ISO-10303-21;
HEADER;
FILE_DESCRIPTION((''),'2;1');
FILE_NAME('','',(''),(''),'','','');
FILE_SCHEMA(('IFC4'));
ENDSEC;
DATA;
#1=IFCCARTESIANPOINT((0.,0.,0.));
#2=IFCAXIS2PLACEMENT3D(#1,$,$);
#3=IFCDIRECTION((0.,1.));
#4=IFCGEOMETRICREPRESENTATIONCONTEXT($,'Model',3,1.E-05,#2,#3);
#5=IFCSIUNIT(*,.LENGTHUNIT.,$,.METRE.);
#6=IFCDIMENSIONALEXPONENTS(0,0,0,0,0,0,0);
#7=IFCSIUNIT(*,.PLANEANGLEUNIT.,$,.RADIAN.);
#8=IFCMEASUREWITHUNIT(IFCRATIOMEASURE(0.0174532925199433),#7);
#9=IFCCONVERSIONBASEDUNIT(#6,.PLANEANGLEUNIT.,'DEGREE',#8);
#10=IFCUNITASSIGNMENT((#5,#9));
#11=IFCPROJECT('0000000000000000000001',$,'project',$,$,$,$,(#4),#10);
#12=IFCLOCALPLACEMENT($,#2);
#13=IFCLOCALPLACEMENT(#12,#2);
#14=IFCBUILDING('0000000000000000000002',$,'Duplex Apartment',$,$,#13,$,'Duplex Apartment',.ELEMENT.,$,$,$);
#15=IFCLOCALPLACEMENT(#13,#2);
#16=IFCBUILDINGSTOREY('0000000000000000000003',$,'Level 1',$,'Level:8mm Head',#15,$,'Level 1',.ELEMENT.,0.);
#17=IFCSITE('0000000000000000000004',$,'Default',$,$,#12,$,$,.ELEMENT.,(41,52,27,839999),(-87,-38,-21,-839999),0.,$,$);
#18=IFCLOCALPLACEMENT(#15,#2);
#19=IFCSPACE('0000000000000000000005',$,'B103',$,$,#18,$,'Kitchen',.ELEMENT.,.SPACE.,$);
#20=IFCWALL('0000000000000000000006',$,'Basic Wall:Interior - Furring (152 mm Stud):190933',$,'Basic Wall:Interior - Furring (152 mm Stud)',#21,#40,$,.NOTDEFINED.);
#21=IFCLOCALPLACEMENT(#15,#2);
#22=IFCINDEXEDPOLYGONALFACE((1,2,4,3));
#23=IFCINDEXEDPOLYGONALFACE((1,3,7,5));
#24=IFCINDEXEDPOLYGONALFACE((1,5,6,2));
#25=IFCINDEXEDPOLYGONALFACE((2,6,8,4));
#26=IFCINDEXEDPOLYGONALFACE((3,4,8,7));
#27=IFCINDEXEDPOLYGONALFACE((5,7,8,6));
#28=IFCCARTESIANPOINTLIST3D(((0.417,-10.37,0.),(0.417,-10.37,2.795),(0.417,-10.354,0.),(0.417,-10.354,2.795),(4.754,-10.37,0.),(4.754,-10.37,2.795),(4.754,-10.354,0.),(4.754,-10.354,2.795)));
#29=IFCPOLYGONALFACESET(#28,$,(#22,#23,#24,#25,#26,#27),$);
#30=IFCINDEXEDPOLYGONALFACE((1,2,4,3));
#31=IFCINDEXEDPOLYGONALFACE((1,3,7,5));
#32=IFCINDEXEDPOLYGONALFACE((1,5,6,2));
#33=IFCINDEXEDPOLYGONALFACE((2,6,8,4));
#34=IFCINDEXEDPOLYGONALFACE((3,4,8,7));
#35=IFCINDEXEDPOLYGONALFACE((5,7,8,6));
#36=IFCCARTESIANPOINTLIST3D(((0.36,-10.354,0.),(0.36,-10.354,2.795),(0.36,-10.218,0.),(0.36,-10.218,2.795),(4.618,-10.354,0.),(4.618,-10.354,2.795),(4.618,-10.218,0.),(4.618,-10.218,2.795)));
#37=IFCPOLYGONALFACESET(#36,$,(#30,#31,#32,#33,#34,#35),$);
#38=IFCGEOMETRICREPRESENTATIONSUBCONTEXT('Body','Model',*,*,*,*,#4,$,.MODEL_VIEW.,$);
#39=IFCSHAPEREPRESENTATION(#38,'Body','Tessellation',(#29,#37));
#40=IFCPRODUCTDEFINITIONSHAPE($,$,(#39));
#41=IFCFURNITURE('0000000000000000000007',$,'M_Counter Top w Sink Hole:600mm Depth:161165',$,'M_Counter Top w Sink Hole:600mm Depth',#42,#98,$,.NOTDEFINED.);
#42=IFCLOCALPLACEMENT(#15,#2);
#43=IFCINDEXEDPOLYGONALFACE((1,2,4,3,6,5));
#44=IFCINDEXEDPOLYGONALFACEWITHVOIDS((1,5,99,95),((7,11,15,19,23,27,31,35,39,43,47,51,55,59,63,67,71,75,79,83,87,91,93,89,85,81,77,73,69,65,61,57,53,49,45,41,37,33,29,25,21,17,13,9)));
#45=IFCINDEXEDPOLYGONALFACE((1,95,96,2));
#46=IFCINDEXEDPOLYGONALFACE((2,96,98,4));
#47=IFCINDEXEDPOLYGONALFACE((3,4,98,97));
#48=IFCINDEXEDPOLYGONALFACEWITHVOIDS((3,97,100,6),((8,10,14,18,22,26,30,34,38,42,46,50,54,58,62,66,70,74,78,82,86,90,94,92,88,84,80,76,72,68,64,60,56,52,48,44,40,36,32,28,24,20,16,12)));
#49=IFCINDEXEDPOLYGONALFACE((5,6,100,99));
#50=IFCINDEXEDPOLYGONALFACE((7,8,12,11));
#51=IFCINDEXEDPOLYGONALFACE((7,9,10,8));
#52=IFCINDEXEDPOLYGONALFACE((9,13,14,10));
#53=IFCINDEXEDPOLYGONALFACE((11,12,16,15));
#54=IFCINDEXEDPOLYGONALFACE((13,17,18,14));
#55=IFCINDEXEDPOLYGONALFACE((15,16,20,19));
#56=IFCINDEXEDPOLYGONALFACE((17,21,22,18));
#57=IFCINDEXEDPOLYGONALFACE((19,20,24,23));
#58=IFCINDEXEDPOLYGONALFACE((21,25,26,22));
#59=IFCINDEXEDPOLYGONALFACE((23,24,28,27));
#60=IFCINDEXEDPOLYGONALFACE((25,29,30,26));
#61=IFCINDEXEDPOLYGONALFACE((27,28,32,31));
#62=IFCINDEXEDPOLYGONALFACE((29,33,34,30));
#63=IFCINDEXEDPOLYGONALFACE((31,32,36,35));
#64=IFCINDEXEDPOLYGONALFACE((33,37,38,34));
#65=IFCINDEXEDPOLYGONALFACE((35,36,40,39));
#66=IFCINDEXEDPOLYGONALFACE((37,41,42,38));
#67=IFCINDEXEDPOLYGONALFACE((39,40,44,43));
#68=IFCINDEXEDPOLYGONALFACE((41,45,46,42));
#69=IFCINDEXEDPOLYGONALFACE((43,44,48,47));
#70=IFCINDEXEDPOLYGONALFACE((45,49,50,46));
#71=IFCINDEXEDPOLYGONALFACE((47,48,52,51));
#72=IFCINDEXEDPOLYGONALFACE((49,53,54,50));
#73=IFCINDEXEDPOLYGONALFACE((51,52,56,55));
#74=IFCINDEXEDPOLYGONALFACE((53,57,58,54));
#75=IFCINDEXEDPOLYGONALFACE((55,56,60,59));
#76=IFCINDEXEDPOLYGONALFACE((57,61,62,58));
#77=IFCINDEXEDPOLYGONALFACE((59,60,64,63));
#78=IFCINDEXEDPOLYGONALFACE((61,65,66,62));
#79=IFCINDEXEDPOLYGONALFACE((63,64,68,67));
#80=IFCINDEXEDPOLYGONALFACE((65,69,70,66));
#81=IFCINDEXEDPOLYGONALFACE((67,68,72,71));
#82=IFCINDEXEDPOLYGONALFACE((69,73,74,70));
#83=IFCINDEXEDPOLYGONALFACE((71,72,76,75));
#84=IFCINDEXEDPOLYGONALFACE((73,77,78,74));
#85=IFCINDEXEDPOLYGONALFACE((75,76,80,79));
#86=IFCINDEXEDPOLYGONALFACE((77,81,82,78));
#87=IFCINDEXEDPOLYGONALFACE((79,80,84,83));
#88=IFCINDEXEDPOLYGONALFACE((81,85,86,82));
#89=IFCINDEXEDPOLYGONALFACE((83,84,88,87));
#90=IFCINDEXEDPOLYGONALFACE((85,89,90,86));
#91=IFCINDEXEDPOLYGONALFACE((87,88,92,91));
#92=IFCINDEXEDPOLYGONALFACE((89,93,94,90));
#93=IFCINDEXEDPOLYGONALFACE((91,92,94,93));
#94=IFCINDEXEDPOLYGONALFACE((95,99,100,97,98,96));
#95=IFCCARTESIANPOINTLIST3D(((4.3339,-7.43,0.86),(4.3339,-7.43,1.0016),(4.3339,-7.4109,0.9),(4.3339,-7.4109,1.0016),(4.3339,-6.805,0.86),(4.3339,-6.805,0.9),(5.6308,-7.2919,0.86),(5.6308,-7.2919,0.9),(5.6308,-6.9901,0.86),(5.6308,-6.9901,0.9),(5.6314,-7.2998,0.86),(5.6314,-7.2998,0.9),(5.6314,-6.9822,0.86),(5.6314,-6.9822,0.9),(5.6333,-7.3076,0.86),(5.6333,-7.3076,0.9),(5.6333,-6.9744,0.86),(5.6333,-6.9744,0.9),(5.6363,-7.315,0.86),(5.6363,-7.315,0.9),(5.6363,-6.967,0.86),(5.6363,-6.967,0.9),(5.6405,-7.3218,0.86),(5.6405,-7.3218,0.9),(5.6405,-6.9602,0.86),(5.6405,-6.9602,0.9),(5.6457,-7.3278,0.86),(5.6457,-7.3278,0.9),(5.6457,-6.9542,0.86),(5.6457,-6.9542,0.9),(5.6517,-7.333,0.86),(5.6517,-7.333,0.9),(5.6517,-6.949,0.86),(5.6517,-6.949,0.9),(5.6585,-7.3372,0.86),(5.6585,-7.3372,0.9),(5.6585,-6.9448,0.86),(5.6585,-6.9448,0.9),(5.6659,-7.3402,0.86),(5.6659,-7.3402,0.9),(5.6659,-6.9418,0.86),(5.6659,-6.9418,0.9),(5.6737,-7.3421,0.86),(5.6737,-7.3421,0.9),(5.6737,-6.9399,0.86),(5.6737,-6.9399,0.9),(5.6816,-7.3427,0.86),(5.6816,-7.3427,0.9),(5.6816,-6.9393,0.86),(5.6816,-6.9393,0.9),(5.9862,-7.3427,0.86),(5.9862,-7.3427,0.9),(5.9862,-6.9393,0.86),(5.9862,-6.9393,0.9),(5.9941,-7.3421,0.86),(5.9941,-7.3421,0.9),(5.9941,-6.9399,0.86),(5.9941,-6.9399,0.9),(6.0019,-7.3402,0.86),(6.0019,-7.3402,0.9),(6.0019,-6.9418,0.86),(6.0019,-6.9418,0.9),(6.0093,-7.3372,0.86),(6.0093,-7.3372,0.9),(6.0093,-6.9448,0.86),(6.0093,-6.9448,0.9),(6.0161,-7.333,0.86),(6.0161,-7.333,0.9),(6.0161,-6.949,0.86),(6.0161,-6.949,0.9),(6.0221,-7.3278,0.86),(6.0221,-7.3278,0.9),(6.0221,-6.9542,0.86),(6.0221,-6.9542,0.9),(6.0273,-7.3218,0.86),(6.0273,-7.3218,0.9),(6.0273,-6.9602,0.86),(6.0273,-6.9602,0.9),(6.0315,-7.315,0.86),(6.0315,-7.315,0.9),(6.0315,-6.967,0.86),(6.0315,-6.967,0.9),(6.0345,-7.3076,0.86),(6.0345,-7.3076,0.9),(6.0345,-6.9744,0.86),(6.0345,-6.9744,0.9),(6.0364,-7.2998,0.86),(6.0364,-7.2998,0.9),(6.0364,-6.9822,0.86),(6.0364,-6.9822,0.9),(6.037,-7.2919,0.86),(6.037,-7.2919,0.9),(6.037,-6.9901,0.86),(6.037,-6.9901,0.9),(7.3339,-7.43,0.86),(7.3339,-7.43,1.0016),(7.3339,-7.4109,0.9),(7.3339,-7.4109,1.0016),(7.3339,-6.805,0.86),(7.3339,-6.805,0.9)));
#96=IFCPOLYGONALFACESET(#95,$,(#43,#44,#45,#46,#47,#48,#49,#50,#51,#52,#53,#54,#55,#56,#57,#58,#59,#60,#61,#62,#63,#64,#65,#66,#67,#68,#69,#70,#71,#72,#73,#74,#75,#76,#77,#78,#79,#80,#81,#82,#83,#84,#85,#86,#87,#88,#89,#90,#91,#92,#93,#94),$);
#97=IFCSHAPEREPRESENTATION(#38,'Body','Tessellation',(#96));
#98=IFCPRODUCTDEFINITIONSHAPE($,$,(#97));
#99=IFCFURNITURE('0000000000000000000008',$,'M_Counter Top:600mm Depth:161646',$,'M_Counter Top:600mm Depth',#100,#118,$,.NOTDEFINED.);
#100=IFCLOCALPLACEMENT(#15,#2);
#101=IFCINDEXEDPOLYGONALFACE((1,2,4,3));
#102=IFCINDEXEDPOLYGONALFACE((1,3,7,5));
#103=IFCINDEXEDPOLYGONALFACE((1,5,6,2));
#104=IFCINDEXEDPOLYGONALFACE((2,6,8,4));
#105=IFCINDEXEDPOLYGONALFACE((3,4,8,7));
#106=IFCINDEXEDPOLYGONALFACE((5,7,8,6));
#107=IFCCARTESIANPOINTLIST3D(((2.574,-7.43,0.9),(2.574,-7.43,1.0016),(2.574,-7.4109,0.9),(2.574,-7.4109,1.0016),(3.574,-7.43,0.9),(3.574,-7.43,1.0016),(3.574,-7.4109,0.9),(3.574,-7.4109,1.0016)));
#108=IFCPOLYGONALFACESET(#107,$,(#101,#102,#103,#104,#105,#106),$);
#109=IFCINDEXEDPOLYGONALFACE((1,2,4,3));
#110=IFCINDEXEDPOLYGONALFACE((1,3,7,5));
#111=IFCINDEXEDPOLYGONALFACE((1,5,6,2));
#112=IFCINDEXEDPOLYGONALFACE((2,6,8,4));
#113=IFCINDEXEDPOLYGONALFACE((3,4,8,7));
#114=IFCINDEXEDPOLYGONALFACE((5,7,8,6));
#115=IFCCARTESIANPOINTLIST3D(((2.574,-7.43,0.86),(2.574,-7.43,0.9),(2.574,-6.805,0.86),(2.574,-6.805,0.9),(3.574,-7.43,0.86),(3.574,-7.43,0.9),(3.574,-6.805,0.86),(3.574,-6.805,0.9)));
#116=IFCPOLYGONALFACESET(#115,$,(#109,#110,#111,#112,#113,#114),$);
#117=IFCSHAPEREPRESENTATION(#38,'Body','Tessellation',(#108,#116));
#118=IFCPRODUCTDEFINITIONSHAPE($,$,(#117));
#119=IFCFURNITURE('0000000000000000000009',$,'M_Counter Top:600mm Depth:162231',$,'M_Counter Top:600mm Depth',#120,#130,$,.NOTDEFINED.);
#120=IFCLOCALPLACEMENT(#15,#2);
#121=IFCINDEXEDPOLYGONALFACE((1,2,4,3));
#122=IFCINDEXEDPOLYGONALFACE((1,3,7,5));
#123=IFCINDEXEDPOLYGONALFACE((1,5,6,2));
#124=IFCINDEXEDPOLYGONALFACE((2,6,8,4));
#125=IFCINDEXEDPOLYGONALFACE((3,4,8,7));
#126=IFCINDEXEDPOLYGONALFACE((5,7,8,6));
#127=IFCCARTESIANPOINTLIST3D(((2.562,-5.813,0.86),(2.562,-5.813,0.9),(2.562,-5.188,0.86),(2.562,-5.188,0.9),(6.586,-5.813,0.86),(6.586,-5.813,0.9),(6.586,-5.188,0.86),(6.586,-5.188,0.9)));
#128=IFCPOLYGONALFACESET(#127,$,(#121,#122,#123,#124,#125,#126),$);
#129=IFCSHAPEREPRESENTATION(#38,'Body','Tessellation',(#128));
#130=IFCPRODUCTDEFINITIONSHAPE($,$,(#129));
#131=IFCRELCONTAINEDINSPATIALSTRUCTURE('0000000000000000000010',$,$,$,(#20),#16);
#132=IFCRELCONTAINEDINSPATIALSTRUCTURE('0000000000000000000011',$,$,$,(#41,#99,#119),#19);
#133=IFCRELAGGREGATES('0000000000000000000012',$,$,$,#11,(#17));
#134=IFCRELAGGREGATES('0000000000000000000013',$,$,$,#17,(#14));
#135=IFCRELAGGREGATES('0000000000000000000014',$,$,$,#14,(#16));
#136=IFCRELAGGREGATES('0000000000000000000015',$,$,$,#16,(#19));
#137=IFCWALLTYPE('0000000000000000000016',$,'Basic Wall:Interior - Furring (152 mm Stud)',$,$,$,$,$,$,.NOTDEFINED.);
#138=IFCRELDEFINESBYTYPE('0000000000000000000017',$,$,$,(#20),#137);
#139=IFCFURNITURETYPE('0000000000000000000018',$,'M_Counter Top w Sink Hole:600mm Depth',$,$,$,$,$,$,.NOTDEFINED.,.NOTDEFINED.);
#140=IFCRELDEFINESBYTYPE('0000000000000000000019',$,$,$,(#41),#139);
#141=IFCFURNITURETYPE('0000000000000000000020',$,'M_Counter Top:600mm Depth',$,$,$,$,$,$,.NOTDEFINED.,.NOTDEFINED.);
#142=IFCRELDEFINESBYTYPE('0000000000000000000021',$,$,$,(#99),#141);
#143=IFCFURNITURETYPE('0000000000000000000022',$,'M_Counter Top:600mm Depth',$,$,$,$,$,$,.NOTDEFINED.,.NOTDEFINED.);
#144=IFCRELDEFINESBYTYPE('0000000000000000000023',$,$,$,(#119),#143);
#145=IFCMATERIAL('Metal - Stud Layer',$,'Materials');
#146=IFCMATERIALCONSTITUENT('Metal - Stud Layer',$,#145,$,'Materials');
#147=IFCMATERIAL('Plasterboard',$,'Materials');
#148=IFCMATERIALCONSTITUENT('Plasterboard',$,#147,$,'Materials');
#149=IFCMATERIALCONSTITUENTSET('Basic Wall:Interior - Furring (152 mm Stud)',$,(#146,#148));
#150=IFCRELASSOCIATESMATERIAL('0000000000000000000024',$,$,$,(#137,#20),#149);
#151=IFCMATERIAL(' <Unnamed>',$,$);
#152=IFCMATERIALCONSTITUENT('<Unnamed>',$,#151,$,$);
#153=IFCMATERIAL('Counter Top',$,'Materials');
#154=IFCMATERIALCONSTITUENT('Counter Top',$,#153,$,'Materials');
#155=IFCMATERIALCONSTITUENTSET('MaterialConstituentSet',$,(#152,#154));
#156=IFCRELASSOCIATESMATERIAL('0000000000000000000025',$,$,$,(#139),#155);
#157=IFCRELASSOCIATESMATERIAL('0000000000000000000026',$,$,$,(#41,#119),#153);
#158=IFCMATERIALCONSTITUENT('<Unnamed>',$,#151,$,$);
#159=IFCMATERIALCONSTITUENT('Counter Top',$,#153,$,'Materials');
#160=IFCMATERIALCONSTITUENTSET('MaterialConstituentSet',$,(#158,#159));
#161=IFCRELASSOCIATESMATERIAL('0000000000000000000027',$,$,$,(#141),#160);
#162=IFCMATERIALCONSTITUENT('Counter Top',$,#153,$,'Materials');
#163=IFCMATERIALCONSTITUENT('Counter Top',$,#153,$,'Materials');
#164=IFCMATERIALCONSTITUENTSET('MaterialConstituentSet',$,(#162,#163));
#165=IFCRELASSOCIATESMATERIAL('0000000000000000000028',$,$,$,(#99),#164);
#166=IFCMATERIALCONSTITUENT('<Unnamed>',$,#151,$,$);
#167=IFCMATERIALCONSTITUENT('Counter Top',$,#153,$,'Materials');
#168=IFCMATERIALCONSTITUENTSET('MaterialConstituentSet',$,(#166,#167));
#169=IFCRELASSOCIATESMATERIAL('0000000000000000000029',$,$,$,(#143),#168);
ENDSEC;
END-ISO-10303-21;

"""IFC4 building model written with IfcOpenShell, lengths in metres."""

from ifc_helpers import new_model, entity, si_unit, converted_unit, direction, frame, origin, place, context, subcontext, project, spatial, indexed_curve, outline, extrude, source, transform, mapped, material, constituent, constituent_set, type_object, type_shapes, element, save


model = new_model("IFC4")

# Units and contexts
model_context = context("Model", 3, precision=1e-05, world=origin(), true_north=direction((0.0, 1.0)))
body_context = subcontext(model_context, "Body", "Model", "MODEL_VIEW")
ifc_project = project(units=[si_unit("LENGTHUNIT", "METRE"), converted_unit("PLANEANGLEUNIT", "DEGREE", entity("IfcRatioMeasure", 0.0174532925199433), si_unit("PLANEANGLEUNIT", "RADIAN"), dimensions=[0, 0, 0, 0, 0, 0, 0])], contexts=[model_context])

# Site, building, storey
site_placement = place(None, origin())
site = spatial("IfcSite", under=ifc_project, at=site_placement, Name="Default", CompositionType="ELEMENT", RefLatitude=(41, 52, 27, 839999), RefLongitude=(-87, -38, -21, -839999), RefElevation=0.0)
building_placement = place(site_placement, origin())
building = spatial("IfcBuilding", under=site, at=building_placement, Name="Duplex Apartment", LongName="Duplex Apartment", CompositionType="ELEMENT")
storey_placement = place(building_placement, origin())
storey = spatial("IfcBuildingStorey", under=building, at=storey_placement, Name="Level 1", ObjectType="Level:8mm Head", LongName="Level 1", CompositionType="ELEMENT", Elevation=0.0)

# Shared definitions
ifc_material_1 = material(Name="Plasterboard", Category="Materials")
ifc_material_2 = material(Name="Metal - Stud Layer", Category="Materials")

# Wall
ifc_constituent_1 = constituent(ifc_material_2, Name="Metal - Stud Layer", Category="Materials")
ifc_constituent_2 = constituent(ifc_material_1, Name="Plasterboard", Category="Materials")
ifc_constituent_set_1 = constituent_set(constituents=[ifc_constituent_1, ifc_constituent_2], Name="Basic Wall:Interior - Furring (152 mm Stud)")
wall_type_1 = type_object("IfcWallType", Name="Basic Wall:Interior - Furring (152 mm Stud)", PredefinedType="NOTDEFINED", material=ifc_constituent_set_1)
wall_1_placement = place(storey_placement, frame((0.417, -10.294, 0.0)))
element("IfcWall", 1, at=wall_1_placement, inside=storey, type_object=wall_type_1, material=ifc_constituent_set_1, Name="Basic Wall:Interior - Furring (152 mm Stud):190933", ObjectType="Basic Wall:Interior - Furring (152 mm Stud)", PredefinedType="NOTDEFINED", context=body_context, shape_type="SweptSolid", body=[
    extrude(outline(indexed_curve([(-0.008, -2.1685), (0.008, -2.1685), (0.008, 2.1685), (-0.008, 2.1685), (-0.008, -2.1685)], self_intersect=False)), frame((2.1685, -0.068, 0.0), z_axis=(0.0, 0.0, 1.0), x_axis=(0.0, 1.0, 0.0)), (0.0, 0.0, 1.0), 2.795),
    extrude(outline(indexed_curve([(-0.068, -2.129), (0.068, -2.129), (0.068, 2.129), (-0.068, 2.129), (-0.068, -2.129)], self_intersect=False)), frame((2.072, 0.008, 0.0), z_axis=(0.0, 0.0, 1.0), x_axis=(0.0, -1.0, 0.0)), (0.0, 0.0, 1.0), 2.795),
])

# Shared definitions
space_1_placement = place(storey_placement, origin())
space_1 = spatial("IfcSpace", under=storey, at=space_1_placement, Name="B103", LongName="Kitchen", CompositionType="ELEMENT", PredefinedType="SPACE")

# Furniture, opening
ifc_material_3 = material(Name="Counter Top", Category="Materials")
ifc_material_4 = material(Name=" <Unnamed>")
ifc_constituent_3 = constituent(ifc_material_4, Name="<Unnamed>")
ifc_constituent_4 = constituent(ifc_material_3, Name="Counter Top", Category="Materials")
ifc_constituent_set_2 = constituent_set(constituents=[ifc_constituent_3, ifc_constituent_4], Name="MaterialConstituentSet")
furniture_type_1 = type_object("IfcFurnitureType", Name="M_Counter Top w Sink Hole:600mm Depth", AssemblyPlace="NOTDEFINED", PredefinedType="NOTDEFINED", material=ifc_constituent_set_2)
shared_shape_1 = source(origin(), body_context, "Body", "SweptSolid", [
    extrude(outline(indexed_curve([(-0.0605, -0.2147), (0.0811, -0.2147), (0.0811, -0.1956), (-0.0205, -0.1956), (-0.0205, 0.4103), (-0.0605, 0.4103), (-0.0605, -0.2147)], self_intersect=False)), frame((-1.2005, -0.2147, 0.9205), z_axis=(1.0, 0.0, 0.0), x_axis=(0.0, 0.0, 1.0)), (0.0, 0.0, 1.0), 3.0),
])
type_shapes(furniture_type_1, [shared_shape_1])
furniture_1_placement = place(space_1_placement, frame((6.1334, -7.43, 0.0), z_axis=(0.0, 0.0, 1.0), x_axis=(-1.0, 0.0, 0.0)))
furniture_1 = element("IfcFurniture", 2, at=furniture_1_placement, inside=space_1, type_object=furniture_type_1, material=ifc_material_3, Name="M_Counter Top w Sink Hole:600mm Depth:161165", ObjectType="M_Counter Top w Sink Hole:600mm Depth", PredefinedType="NOTDEFINED", context=body_context, shape_type="MappedRepresentation", body=[
    mapped(shared_shape_1, transform((0.0, 0.0, 0.0), scale=1.0)),
])
opening_1_placement = place(storey_placement, frame((6.1334, -7.43, 0.0)))
element("IfcOpeningElement", 3, at=opening_1_placement, cuts=furniture_1, ObjectType="Opening", PredefinedType="OPENING", context=body_context, shape_type="SweptSolid", body=[
    extrude(outline(indexed_curve([(-0.1523, -0.2017), (0.1523, -0.2017), (0.1602, -0.2011), (0.168, -0.1992), (0.1754, -0.1962), (0.1822, -0.192), (0.1882, -0.1868), (0.1934, -0.1808), (0.1976, -0.174), (0.2006, -0.1666), (0.2025, -0.1588), (0.2031, -0.1509), (0.2031, 0.1509), (0.2025, 0.1588), (0.2006, 0.1666), (0.1976, 0.174), (0.1934, 0.1808), (0.1882, 0.1868), (0.1822, 0.192), (0.1754, 0.1962), (0.168, 0.1992), (0.1602, 0.2011), (0.1523, 0.2017), (-0.1523, 0.2017), (-0.1602, 0.2011), (-0.168, 0.1992), (-0.1754, 0.1962), (-0.1822, 0.192), (-0.1882, 0.1868), (-0.1934, 0.1808), (-0.1976, 0.174), (-0.2006, 0.1666), (-0.2025, 0.1588), (-0.2031, 0.1509), (-0.2031, -0.1509), (-0.2025, -0.1588), (-0.2006, -0.1666), (-0.1976, -0.174), (-0.1934, -0.1808), (-0.1882, -0.1868), (-0.1822, -0.192), (-0.1754, -0.1962), (-0.168, -0.1992), (-0.1602, -0.2011), (-0.1523, -0.2017)], self_intersect=False)), frame((-0.2995, 0.289, 0.86)), (0.0, 0.0, 1.0), 0.04),
])

# Furniture
ifc_constituent_5 = constituent(ifc_material_3, Name="Counter Top", Category="Materials")
ifc_constituent_6 = constituent(ifc_material_3, Name="Counter Top", Category="Materials")
ifc_constituent_set_3 = constituent_set(constituents=[ifc_constituent_5, ifc_constituent_6], Name="MaterialConstituentSet")
ifc_constituent_7 = constituent(ifc_material_4, Name="<Unnamed>")
ifc_constituent_8 = constituent(ifc_material_3, Name="Counter Top", Category="Materials")
ifc_constituent_set_4 = constituent_set(constituents=[ifc_constituent_7, ifc_constituent_8], Name="MaterialConstituentSet")
furniture_type_2 = type_object("IfcFurnitureType", Name="M_Counter Top:600mm Depth", AssemblyPlace="NOTDEFINED", PredefinedType="NOTDEFINED", material=ifc_constituent_set_4)
shared_shape_2 = source(origin(), body_context, "Body", "SweptSolid", [
    extrude(outline(indexed_curve([(-0.0095, -0.5), (0.0095, -0.5), (0.0095, 0.5), (-0.0095, 0.5), (-0.0095, -0.5)], self_intersect=False)), frame((-0.7005, -0.0095, 0.9), z_axis=(0.0, 0.0, 1.0), x_axis=(0.0, -1.0, 0.0)), (0.0, 0.0, 1.0), 0.1016),
    extrude(outline(indexed_curve([(-0.5, -0.3125), (0.5, -0.3125), (0.5, 0.3125), (-0.5, 0.3125), (-0.5, -0.3125)], self_intersect=False)), frame((-0.7005, -0.3125, 0.86), z_axis=(0.0, 0.0, 1.0), x_axis=(-1.0, 0.0, 0.0)), (0.0, 0.0, 1.0), 0.04),
])
type_shapes(furniture_type_2, [shared_shape_2])
furniture_2_placement = place(space_1_placement, frame((2.3735, -7.43, 0.0), z_axis=(0.0, 0.0, 1.0), x_axis=(-1.0, 0.0, 0.0)))
element("IfcFurniture", 4, at=furniture_2_placement, inside=space_1, type_object=furniture_type_2, material=ifc_constituent_set_3, Name="M_Counter Top:600mm Depth:161646", ObjectType="M_Counter Top:600mm Depth", PredefinedType="NOTDEFINED", context=body_context, shape_type="MappedRepresentation", body=[
    mapped(shared_shape_2, transform((0.0, 0.0, 0.0), scale=1.0)),
])
ifc_constituent_9 = constituent(ifc_material_4, Name="<Unnamed>")
ifc_constituent_10 = constituent(ifc_material_3, Name="Counter Top", Category="Materials")
ifc_constituent_set_5 = constituent_set(constituents=[ifc_constituent_9, ifc_constituent_10], Name="MaterialConstituentSet")
furniture_type_3 = type_object("IfcFurnitureType", Name="M_Counter Top:600mm Depth", AssemblyPlace="NOTDEFINED", PredefinedType="NOTDEFINED", material=ifc_constituent_set_5)
shared_shape_3 = source(origin(), body_context, "Body", "SweptSolid", [
    extrude(outline(indexed_curve([(-2.012, -0.3125), (2.012, -0.3125), (2.012, 0.3125), (-2.012, 0.3125), (-2.012, -0.3125)], self_intersect=False)), frame((0.8115, -0.3125, 0.86), z_axis=(0.0, 0.0, 1.0), x_axis=(-1.0, 0.0, 0.0)), (0.0, 0.0, 1.0), 0.04),
])
type_shapes(furniture_type_3, [shared_shape_3])
furniture_3_placement = place(space_1_placement, frame((3.7625, -5.188, 0.0)))
element("IfcFurniture", 5, at=furniture_3_placement, inside=space_1, type_object=furniture_type_3, material=ifc_material_3, Name="M_Counter Top:600mm Depth:162231", ObjectType="M_Counter Top:600mm Depth", PredefinedType="NOTDEFINED", context=body_context, shape_type="MappedRepresentation", body=[
    mapped(shared_shape_3, transform((0.0, 0.0, 0.0), scale=1.0)),
])

save(model, "model.ifc")
